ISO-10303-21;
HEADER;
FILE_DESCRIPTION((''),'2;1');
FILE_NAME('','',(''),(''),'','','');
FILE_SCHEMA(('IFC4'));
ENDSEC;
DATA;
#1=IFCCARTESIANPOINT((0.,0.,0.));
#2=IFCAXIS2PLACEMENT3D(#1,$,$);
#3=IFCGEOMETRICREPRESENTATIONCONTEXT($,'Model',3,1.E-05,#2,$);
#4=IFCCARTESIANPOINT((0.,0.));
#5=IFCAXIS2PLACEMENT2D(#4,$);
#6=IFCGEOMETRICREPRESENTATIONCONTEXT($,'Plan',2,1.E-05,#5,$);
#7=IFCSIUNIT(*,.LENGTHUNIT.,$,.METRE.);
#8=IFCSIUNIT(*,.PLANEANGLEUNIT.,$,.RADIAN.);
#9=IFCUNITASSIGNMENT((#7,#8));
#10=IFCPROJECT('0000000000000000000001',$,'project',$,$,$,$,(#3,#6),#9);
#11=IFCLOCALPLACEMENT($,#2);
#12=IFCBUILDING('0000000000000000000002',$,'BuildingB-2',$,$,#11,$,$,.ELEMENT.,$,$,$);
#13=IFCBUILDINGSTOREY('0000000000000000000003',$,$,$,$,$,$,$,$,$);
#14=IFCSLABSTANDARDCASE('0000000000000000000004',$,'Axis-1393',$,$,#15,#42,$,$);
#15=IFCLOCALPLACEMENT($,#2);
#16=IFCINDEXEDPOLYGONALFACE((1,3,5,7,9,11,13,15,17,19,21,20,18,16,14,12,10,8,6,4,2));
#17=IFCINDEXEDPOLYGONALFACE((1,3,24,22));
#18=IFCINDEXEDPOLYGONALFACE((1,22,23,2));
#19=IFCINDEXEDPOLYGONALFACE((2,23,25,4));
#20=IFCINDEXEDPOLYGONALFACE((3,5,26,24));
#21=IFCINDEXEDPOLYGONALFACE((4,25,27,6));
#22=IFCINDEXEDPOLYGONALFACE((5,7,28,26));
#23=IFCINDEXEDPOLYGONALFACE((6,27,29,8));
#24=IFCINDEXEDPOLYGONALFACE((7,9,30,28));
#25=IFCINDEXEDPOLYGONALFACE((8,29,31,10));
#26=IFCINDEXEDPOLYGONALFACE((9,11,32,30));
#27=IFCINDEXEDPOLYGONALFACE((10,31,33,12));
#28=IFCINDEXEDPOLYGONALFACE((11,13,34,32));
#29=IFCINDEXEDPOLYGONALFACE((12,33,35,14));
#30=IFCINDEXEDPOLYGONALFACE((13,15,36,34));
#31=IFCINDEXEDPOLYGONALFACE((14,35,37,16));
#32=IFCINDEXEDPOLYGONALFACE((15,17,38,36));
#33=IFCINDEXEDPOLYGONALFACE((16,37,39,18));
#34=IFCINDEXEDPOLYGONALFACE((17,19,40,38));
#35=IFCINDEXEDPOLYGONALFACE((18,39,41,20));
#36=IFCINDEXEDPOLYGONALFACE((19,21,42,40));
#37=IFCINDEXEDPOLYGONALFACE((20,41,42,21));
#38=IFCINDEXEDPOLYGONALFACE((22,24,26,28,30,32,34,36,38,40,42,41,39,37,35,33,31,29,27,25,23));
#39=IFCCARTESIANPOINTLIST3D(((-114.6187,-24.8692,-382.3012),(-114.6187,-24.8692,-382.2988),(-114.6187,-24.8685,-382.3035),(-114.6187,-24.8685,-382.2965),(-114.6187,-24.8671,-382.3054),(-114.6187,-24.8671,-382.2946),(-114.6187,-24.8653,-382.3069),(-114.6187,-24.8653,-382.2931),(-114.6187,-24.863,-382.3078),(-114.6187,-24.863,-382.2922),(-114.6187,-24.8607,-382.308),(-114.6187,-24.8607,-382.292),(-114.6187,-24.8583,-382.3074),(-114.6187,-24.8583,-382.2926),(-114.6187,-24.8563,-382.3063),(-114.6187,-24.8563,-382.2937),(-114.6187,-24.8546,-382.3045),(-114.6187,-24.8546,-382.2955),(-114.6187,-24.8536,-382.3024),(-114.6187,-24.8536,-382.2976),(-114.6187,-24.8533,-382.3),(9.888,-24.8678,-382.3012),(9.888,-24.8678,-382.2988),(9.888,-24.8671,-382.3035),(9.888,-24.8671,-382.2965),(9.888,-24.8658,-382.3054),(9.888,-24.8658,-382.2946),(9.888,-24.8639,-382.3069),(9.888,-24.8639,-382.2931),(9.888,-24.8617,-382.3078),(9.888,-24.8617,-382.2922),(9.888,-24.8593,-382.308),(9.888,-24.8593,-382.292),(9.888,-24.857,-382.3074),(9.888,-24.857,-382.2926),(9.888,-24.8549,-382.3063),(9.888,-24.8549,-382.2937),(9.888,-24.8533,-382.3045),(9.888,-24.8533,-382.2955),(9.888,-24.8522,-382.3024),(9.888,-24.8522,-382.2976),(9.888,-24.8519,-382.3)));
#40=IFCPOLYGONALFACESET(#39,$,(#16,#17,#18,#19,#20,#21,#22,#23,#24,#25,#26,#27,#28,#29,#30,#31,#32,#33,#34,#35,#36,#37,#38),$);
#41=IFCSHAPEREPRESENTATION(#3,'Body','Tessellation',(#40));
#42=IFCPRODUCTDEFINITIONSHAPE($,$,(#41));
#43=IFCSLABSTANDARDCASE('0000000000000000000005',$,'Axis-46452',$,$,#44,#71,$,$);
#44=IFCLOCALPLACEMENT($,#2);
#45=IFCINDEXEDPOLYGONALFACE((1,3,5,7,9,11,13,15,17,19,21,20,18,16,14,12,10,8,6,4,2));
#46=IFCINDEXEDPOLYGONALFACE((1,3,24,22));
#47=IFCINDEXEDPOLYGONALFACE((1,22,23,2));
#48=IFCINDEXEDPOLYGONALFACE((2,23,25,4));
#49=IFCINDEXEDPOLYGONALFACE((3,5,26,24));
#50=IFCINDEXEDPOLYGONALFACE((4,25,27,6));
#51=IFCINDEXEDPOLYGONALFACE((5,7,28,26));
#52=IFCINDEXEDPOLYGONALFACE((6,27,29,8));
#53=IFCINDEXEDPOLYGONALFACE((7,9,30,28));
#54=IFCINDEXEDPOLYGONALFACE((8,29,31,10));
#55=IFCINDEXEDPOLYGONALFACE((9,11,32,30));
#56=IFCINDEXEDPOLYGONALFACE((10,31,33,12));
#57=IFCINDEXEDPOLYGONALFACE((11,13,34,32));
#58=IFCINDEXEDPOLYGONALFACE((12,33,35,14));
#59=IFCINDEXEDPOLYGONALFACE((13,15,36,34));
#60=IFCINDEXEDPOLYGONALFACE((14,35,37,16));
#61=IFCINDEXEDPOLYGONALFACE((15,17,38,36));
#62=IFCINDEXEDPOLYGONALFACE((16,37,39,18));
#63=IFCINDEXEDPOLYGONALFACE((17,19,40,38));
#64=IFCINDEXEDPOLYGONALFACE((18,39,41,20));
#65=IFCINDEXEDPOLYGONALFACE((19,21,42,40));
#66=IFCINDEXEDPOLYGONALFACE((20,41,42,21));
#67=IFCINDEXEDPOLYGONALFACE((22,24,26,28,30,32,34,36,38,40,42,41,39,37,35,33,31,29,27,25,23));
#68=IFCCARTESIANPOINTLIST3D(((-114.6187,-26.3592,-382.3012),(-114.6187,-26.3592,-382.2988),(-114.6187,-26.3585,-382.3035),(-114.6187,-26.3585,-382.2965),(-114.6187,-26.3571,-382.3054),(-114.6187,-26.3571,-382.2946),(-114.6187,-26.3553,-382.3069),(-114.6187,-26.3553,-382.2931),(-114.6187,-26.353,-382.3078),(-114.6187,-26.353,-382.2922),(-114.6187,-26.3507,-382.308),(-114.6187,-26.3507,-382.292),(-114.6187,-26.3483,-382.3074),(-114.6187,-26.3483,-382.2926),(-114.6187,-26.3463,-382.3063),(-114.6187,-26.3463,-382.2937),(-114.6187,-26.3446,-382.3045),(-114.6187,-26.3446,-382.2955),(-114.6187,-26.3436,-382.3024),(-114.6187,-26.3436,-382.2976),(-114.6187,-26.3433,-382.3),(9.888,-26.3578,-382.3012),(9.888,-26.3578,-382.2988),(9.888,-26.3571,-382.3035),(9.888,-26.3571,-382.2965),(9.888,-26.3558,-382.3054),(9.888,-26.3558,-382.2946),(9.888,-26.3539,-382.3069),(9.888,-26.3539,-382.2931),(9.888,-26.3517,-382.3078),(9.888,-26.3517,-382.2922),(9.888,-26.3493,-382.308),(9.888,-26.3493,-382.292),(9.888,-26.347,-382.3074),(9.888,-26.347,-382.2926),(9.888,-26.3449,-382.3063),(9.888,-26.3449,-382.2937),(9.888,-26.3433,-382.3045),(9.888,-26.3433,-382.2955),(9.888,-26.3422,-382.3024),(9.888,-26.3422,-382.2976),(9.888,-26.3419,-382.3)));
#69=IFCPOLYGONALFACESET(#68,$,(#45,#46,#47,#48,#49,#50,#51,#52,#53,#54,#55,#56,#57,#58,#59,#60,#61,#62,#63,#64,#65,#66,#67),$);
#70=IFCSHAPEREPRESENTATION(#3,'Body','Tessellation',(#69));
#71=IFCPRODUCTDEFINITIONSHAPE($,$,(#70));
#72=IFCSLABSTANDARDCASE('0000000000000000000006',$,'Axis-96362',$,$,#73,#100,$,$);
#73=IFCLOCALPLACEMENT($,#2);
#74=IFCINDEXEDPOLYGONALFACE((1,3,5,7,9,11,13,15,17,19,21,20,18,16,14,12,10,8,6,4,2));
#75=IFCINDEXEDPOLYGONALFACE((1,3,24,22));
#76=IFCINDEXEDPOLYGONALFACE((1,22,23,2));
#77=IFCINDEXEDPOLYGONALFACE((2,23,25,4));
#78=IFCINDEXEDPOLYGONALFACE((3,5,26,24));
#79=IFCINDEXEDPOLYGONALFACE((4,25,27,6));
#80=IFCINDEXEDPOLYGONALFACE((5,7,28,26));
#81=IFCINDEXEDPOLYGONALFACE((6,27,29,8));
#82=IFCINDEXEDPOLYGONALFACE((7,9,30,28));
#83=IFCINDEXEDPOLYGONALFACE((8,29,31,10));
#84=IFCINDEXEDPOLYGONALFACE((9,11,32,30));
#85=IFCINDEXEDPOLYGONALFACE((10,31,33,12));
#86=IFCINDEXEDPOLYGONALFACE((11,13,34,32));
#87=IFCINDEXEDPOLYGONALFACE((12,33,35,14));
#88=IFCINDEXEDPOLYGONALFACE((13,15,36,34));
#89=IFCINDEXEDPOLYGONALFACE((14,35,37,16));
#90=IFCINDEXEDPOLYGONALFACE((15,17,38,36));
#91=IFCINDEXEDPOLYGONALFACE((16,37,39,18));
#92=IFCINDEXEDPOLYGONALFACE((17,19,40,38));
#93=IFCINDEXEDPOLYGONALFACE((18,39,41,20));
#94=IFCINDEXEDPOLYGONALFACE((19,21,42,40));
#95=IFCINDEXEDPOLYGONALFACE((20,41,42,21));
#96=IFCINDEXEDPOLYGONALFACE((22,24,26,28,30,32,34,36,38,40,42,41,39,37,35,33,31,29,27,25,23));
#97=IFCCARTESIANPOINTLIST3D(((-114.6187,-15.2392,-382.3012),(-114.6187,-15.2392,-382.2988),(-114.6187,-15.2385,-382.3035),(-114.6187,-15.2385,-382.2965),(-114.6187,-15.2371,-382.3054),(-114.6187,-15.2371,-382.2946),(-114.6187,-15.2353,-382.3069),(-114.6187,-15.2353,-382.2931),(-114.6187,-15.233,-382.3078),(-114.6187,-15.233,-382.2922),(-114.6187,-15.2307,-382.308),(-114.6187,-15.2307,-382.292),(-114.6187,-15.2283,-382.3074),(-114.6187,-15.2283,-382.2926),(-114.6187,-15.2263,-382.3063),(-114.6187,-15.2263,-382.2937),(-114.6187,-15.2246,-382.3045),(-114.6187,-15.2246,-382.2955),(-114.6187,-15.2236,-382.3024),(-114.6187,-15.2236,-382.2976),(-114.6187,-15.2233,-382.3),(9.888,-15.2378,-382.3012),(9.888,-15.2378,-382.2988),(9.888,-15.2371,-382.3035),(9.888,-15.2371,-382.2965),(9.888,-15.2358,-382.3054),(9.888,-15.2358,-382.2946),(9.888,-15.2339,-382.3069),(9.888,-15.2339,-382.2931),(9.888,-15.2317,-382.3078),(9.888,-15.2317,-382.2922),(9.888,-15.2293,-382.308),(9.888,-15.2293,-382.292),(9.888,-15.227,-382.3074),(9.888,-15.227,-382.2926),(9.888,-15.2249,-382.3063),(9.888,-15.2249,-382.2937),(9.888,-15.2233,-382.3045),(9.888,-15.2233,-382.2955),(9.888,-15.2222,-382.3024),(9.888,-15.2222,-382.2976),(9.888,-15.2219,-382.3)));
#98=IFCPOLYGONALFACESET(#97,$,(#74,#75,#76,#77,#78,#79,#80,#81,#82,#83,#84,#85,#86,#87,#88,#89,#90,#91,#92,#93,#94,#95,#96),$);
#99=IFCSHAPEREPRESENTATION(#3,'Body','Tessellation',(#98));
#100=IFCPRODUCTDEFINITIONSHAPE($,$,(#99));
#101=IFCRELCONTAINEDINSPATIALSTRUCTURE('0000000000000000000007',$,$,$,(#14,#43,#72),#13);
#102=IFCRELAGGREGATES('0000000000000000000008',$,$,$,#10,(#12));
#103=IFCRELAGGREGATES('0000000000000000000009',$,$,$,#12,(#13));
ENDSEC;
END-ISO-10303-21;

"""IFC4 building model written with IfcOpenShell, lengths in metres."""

from ifc_helpers import new_model, entity, si_unit, origin, origin_2d, place, context, project, spatial, element, save


model = new_model("IFC4")

# Units and contexts
model_context = context("Model", 3, precision=1e-05, world=origin())
plan_context = context("Plan", 2, precision=1e-05, world=origin_2d())
ifc_project = project(units=[si_unit("LENGTHUNIT", "METRE"), si_unit("PLANEANGLEUNIT", "RADIAN")], contexts=[model_context, plan_context])

# Building, storey
building_placement = place(None, origin())
building = spatial("IfcBuilding", under=ifc_project, at=building_placement, Name="BuildingB-2", CompositionType="ELEMENT")
storey = spatial("IfcBuildingStorey", under=building)

# Slabs
element("IfcSlabStandardCase", 1, inside=storey, Name="Axis-1393", context=model_context, shape_type="AdvancedSweptSolid", body=[
    entity("IfcSurfaceCurveSweptAreaSolid", entity("IfcCircleProfileDef", "AREA", None, None, 0.008), None, entity("IfcPolyline", [entity("IfcCartesianPoint", [-9.888, 24.8599, 382.3]), entity("IfcCartesianPoint", [114.6187, 24.8613, 382.3])]), None, None, entity("IfcPlane", entity("IfcAxis2Placement3D", entity("IfcCartesianPoint", [-9.888, 24.8599, 382.3]), entity("IfcDirection", [0.0, 0.0, 1.0]), entity("IfcDirection", [1.0, 0.0, 0.0])))),
    entity("IfcSurfaceCurveSweptAreaSolid", entity("IfcCircleProfileDef", "AREA", None, None, 0.008), None, entity("IfcCircle", entity("IfcAxis2Placement2D", entity("IfcCartesianPoint", [-10.1215, 24.8599, 382.3])), 0.35), None, None, entity("IfcPlane", entity("IfcAxis2Placement3D", entity("IfcCartesianPoint", [-10.1215, 24.8599, 382.3]), entity("IfcDirection", [0.0, 0.0, 1.0]), entity("IfcDirection", [1.0, 0.0, 0.0])))),
    entity("IfcSurfaceCurveSweptAreaSolid", entity("IfcCircleProfileDef", "AREA", None, None, 0.008), None, entity("IfcCircle", entity("IfcAxis2Placement2D", entity("IfcCartesianPoint", [114.8522, 24.8613, 382.3])), 0.35), None, None, entity("IfcPlane", entity("IfcAxis2Placement3D", entity("IfcCartesianPoint", [114.8522, 24.8613, 382.3]), entity("IfcDirection", [0.0, 0.0, 1.0]), entity("IfcDirection", [1.0, 0.0, 0.0])))),
])
element("IfcSlabStandardCase", 2, inside=storey, Name="Axis-46452", context=model_context, shape_type="AdvancedSweptSolid", body=[
    entity("IfcSurfaceCurveSweptAreaSolid", entity("IfcCircleProfileDef", "AREA", None, None, 0.008), None, entity("IfcPolyline", [entity("IfcCartesianPoint", [-9.888, 26.3499, 382.3]), entity("IfcCartesianPoint", [114.6187, 26.3513, 382.3])]), None, None, entity("IfcPlane", entity("IfcAxis2Placement3D", entity("IfcCartesianPoint", [-9.888, 26.3499, 382.3]), entity("IfcDirection", [0.0, 0.0, 1.0]), entity("IfcDirection", [1.0, 0.0, 0.0])))),
    entity("IfcSurfaceCurveSweptAreaSolid", entity("IfcCircleProfileDef", "AREA", None, None, 0.008), None, entity("IfcCircle", entity("IfcAxis2Placement2D", entity("IfcCartesianPoint", [-10.0987, 26.3513, 382.3])), 0.35), None, None, entity("IfcPlane", entity("IfcAxis2Placement3D", entity("IfcCartesianPoint", [-10.0987, 26.3513, 382.3]), entity("IfcDirection", [0.0, 0.0, 1.0]), entity("IfcDirection", [1.0, 0.0, 0.0])))),
    entity("IfcSurfaceCurveSweptAreaSolid", entity("IfcCircleProfileDef", "AREA", None, None, 0.008), None, entity("IfcCircle", entity("IfcAxis2Placement2D", entity("IfcCartesianPoint", [114.8522, 26.3513, 382.3])), 0.35), None, None, entity("IfcPlane", entity("IfcAxis2Placement3D", entity("IfcCartesianPoint", [114.8522, 26.3513, 382.3]), entity("IfcDirection", [0.0, 0.0, 1.0]), entity("IfcDirection", [1.0, 0.0, 0.0])))),
])
element("IfcSlabStandardCase", 3, inside=storey, Name="Axis-96362", context=model_context, shape_type="AdvancedSweptSolid", body=[
    entity("IfcSurfaceCurveSweptAreaSolid", entity("IfcCircleProfileDef", "AREA", None, None, 0.008), None, entity("IfcPolyline", [entity("IfcCartesianPoint", [-9.888, 15.2299, 382.3]), entity("IfcCartesianPoint", [114.6187, 15.2313, 382.3])]), None, None, entity("IfcPlane", entity("IfcAxis2Placement3D", entity("IfcCartesianPoint", [-9.888, 15.2299, 382.3]), entity("IfcDirection", [0.0, 0.0, 1.0]), entity("IfcDirection", [1.0, 0.0, 0.0])))),
    entity("IfcSurfaceCurveSweptAreaSolid", entity("IfcCircleProfileDef", "AREA", None, None, 0.008), None, entity("IfcCircle", entity("IfcAxis2Placement2D", entity("IfcCartesianPoint", [-10.1217, 15.2299, 382.3])), 0.35), None, None, entity("IfcPlane", entity("IfcAxis2Placement3D", entity("IfcCartesianPoint", [-10.1217, 15.2299, 382.3]), entity("IfcDirection", [0.0, 0.0, 1.0]), entity("IfcDirection", [1.0, 0.0, 0.0])))),
    entity("IfcSurfaceCurveSweptAreaSolid", entity("IfcCircleProfileDef", "AREA", None, None, 0.008), None, entity("IfcCircle", entity("IfcAxis2Placement2D", entity("IfcCartesianPoint", [114.8519, 15.2313, 382.3])), 0.35), None, None, entity("IfcPlane", entity("IfcAxis2Placement3D", entity("IfcCartesianPoint", [114.8519, 15.2313, 382.3]), entity("IfcDirection", [0.0, 0.0, 1.0]), entity("IfcDirection", [1.0, 0.0, 0.0])))),
])

save(model, "model.ifc")
